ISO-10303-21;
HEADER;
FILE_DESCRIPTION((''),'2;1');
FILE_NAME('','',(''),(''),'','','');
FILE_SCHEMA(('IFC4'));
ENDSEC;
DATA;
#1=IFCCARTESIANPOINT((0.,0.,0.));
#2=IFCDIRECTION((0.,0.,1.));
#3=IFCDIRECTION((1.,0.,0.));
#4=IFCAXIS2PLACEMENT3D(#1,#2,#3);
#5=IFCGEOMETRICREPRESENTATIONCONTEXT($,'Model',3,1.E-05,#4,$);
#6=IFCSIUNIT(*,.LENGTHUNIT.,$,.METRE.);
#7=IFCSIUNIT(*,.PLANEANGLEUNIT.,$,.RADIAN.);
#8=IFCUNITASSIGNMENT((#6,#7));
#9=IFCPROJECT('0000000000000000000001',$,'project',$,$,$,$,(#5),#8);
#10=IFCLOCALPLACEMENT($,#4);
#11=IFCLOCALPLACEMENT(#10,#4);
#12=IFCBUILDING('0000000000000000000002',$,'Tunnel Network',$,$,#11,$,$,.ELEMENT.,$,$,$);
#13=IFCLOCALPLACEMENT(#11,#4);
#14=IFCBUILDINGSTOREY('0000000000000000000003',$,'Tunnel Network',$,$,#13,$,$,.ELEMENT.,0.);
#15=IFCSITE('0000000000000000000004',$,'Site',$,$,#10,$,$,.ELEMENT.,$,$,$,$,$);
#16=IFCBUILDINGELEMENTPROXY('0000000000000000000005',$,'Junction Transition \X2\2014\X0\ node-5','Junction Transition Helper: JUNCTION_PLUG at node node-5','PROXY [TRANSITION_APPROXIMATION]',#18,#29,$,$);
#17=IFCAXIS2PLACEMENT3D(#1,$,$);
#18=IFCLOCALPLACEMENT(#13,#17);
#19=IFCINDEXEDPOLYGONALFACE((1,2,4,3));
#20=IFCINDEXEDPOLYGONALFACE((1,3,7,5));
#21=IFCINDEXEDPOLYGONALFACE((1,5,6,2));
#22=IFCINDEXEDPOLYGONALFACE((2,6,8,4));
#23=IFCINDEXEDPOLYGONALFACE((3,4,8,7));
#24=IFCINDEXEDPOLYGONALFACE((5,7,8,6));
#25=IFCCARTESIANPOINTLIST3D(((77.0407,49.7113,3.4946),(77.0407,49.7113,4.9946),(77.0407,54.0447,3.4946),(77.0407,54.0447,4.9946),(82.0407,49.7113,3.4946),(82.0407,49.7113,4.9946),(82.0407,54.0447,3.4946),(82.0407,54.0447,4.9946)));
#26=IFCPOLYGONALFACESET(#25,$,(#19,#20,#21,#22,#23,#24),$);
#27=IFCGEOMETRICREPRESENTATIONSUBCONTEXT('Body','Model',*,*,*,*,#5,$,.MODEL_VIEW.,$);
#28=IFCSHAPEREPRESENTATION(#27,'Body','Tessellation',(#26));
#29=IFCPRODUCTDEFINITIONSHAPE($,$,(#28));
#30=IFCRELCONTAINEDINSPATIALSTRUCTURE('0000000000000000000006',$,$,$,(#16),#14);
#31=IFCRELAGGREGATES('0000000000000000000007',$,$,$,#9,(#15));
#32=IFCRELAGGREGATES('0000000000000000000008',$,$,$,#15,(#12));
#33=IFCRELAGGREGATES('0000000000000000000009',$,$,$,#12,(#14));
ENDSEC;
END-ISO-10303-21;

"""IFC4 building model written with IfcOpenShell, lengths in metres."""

from ifc_helpers import new_model, si_unit, frame, origin_with_axes, origin_2d_with_axis, place, context, subcontext, project, spatial, rectangle, extrude, element, save


model = new_model("IFC4")

# Units and contexts
model_context = context("Model", 3, precision=1e-05, world=origin_with_axes())
body_context = subcontext(model_context, "Body", "Model", "MODEL_VIEW")
ifc_project = project(units=[si_unit("LENGTHUNIT", "METRE"), si_unit("PLANEANGLEUNIT", "RADIAN")], contexts=[model_context])

# Site, building, storey
site_placement = place(None, origin_with_axes())
site = spatial("IfcSite", under=ifc_project, at=site_placement, Name="Site", CompositionType="ELEMENT")
building_placement = place(site_placement, origin_with_axes())
building = spatial("IfcBuilding", under=site, at=building_placement, Name="Tunnel Network", CompositionType="ELEMENT")
storey_placement = place(building_placement, origin_with_axes())
storey = spatial("IfcBuildingStorey", under=building, at=storey_placement, Name="Tunnel Network", CompositionType="ELEMENT", Elevation=0.0)

# Building element proxy
proxy_1_placement = place(storey_placement, frame((79.5407, 51.878, 3.4946), z_axis=(0.0, 0.0, 1.0), x_axis=(1.0, 0.0, 0.0)))
element("IfcBuildingElementProxy", 1, at=proxy_1_placement, inside=storey, Name="Junction Transition — node-5", Description="Junction Transition Helper: JUNCTION_PLUG at node node-5", ObjectType="PROXY [TRANSITION_APPROXIMATION]", context=body_context, shape_type="SweptSolid", body=[
    extrude(rectangle(XDim=5.0, YDim=4.3333, at=origin_2d_with_axis()), origin_with_axes(), (0.0, 0.0, 1.0), 1.5),
])

save(model, "model.ifc")
